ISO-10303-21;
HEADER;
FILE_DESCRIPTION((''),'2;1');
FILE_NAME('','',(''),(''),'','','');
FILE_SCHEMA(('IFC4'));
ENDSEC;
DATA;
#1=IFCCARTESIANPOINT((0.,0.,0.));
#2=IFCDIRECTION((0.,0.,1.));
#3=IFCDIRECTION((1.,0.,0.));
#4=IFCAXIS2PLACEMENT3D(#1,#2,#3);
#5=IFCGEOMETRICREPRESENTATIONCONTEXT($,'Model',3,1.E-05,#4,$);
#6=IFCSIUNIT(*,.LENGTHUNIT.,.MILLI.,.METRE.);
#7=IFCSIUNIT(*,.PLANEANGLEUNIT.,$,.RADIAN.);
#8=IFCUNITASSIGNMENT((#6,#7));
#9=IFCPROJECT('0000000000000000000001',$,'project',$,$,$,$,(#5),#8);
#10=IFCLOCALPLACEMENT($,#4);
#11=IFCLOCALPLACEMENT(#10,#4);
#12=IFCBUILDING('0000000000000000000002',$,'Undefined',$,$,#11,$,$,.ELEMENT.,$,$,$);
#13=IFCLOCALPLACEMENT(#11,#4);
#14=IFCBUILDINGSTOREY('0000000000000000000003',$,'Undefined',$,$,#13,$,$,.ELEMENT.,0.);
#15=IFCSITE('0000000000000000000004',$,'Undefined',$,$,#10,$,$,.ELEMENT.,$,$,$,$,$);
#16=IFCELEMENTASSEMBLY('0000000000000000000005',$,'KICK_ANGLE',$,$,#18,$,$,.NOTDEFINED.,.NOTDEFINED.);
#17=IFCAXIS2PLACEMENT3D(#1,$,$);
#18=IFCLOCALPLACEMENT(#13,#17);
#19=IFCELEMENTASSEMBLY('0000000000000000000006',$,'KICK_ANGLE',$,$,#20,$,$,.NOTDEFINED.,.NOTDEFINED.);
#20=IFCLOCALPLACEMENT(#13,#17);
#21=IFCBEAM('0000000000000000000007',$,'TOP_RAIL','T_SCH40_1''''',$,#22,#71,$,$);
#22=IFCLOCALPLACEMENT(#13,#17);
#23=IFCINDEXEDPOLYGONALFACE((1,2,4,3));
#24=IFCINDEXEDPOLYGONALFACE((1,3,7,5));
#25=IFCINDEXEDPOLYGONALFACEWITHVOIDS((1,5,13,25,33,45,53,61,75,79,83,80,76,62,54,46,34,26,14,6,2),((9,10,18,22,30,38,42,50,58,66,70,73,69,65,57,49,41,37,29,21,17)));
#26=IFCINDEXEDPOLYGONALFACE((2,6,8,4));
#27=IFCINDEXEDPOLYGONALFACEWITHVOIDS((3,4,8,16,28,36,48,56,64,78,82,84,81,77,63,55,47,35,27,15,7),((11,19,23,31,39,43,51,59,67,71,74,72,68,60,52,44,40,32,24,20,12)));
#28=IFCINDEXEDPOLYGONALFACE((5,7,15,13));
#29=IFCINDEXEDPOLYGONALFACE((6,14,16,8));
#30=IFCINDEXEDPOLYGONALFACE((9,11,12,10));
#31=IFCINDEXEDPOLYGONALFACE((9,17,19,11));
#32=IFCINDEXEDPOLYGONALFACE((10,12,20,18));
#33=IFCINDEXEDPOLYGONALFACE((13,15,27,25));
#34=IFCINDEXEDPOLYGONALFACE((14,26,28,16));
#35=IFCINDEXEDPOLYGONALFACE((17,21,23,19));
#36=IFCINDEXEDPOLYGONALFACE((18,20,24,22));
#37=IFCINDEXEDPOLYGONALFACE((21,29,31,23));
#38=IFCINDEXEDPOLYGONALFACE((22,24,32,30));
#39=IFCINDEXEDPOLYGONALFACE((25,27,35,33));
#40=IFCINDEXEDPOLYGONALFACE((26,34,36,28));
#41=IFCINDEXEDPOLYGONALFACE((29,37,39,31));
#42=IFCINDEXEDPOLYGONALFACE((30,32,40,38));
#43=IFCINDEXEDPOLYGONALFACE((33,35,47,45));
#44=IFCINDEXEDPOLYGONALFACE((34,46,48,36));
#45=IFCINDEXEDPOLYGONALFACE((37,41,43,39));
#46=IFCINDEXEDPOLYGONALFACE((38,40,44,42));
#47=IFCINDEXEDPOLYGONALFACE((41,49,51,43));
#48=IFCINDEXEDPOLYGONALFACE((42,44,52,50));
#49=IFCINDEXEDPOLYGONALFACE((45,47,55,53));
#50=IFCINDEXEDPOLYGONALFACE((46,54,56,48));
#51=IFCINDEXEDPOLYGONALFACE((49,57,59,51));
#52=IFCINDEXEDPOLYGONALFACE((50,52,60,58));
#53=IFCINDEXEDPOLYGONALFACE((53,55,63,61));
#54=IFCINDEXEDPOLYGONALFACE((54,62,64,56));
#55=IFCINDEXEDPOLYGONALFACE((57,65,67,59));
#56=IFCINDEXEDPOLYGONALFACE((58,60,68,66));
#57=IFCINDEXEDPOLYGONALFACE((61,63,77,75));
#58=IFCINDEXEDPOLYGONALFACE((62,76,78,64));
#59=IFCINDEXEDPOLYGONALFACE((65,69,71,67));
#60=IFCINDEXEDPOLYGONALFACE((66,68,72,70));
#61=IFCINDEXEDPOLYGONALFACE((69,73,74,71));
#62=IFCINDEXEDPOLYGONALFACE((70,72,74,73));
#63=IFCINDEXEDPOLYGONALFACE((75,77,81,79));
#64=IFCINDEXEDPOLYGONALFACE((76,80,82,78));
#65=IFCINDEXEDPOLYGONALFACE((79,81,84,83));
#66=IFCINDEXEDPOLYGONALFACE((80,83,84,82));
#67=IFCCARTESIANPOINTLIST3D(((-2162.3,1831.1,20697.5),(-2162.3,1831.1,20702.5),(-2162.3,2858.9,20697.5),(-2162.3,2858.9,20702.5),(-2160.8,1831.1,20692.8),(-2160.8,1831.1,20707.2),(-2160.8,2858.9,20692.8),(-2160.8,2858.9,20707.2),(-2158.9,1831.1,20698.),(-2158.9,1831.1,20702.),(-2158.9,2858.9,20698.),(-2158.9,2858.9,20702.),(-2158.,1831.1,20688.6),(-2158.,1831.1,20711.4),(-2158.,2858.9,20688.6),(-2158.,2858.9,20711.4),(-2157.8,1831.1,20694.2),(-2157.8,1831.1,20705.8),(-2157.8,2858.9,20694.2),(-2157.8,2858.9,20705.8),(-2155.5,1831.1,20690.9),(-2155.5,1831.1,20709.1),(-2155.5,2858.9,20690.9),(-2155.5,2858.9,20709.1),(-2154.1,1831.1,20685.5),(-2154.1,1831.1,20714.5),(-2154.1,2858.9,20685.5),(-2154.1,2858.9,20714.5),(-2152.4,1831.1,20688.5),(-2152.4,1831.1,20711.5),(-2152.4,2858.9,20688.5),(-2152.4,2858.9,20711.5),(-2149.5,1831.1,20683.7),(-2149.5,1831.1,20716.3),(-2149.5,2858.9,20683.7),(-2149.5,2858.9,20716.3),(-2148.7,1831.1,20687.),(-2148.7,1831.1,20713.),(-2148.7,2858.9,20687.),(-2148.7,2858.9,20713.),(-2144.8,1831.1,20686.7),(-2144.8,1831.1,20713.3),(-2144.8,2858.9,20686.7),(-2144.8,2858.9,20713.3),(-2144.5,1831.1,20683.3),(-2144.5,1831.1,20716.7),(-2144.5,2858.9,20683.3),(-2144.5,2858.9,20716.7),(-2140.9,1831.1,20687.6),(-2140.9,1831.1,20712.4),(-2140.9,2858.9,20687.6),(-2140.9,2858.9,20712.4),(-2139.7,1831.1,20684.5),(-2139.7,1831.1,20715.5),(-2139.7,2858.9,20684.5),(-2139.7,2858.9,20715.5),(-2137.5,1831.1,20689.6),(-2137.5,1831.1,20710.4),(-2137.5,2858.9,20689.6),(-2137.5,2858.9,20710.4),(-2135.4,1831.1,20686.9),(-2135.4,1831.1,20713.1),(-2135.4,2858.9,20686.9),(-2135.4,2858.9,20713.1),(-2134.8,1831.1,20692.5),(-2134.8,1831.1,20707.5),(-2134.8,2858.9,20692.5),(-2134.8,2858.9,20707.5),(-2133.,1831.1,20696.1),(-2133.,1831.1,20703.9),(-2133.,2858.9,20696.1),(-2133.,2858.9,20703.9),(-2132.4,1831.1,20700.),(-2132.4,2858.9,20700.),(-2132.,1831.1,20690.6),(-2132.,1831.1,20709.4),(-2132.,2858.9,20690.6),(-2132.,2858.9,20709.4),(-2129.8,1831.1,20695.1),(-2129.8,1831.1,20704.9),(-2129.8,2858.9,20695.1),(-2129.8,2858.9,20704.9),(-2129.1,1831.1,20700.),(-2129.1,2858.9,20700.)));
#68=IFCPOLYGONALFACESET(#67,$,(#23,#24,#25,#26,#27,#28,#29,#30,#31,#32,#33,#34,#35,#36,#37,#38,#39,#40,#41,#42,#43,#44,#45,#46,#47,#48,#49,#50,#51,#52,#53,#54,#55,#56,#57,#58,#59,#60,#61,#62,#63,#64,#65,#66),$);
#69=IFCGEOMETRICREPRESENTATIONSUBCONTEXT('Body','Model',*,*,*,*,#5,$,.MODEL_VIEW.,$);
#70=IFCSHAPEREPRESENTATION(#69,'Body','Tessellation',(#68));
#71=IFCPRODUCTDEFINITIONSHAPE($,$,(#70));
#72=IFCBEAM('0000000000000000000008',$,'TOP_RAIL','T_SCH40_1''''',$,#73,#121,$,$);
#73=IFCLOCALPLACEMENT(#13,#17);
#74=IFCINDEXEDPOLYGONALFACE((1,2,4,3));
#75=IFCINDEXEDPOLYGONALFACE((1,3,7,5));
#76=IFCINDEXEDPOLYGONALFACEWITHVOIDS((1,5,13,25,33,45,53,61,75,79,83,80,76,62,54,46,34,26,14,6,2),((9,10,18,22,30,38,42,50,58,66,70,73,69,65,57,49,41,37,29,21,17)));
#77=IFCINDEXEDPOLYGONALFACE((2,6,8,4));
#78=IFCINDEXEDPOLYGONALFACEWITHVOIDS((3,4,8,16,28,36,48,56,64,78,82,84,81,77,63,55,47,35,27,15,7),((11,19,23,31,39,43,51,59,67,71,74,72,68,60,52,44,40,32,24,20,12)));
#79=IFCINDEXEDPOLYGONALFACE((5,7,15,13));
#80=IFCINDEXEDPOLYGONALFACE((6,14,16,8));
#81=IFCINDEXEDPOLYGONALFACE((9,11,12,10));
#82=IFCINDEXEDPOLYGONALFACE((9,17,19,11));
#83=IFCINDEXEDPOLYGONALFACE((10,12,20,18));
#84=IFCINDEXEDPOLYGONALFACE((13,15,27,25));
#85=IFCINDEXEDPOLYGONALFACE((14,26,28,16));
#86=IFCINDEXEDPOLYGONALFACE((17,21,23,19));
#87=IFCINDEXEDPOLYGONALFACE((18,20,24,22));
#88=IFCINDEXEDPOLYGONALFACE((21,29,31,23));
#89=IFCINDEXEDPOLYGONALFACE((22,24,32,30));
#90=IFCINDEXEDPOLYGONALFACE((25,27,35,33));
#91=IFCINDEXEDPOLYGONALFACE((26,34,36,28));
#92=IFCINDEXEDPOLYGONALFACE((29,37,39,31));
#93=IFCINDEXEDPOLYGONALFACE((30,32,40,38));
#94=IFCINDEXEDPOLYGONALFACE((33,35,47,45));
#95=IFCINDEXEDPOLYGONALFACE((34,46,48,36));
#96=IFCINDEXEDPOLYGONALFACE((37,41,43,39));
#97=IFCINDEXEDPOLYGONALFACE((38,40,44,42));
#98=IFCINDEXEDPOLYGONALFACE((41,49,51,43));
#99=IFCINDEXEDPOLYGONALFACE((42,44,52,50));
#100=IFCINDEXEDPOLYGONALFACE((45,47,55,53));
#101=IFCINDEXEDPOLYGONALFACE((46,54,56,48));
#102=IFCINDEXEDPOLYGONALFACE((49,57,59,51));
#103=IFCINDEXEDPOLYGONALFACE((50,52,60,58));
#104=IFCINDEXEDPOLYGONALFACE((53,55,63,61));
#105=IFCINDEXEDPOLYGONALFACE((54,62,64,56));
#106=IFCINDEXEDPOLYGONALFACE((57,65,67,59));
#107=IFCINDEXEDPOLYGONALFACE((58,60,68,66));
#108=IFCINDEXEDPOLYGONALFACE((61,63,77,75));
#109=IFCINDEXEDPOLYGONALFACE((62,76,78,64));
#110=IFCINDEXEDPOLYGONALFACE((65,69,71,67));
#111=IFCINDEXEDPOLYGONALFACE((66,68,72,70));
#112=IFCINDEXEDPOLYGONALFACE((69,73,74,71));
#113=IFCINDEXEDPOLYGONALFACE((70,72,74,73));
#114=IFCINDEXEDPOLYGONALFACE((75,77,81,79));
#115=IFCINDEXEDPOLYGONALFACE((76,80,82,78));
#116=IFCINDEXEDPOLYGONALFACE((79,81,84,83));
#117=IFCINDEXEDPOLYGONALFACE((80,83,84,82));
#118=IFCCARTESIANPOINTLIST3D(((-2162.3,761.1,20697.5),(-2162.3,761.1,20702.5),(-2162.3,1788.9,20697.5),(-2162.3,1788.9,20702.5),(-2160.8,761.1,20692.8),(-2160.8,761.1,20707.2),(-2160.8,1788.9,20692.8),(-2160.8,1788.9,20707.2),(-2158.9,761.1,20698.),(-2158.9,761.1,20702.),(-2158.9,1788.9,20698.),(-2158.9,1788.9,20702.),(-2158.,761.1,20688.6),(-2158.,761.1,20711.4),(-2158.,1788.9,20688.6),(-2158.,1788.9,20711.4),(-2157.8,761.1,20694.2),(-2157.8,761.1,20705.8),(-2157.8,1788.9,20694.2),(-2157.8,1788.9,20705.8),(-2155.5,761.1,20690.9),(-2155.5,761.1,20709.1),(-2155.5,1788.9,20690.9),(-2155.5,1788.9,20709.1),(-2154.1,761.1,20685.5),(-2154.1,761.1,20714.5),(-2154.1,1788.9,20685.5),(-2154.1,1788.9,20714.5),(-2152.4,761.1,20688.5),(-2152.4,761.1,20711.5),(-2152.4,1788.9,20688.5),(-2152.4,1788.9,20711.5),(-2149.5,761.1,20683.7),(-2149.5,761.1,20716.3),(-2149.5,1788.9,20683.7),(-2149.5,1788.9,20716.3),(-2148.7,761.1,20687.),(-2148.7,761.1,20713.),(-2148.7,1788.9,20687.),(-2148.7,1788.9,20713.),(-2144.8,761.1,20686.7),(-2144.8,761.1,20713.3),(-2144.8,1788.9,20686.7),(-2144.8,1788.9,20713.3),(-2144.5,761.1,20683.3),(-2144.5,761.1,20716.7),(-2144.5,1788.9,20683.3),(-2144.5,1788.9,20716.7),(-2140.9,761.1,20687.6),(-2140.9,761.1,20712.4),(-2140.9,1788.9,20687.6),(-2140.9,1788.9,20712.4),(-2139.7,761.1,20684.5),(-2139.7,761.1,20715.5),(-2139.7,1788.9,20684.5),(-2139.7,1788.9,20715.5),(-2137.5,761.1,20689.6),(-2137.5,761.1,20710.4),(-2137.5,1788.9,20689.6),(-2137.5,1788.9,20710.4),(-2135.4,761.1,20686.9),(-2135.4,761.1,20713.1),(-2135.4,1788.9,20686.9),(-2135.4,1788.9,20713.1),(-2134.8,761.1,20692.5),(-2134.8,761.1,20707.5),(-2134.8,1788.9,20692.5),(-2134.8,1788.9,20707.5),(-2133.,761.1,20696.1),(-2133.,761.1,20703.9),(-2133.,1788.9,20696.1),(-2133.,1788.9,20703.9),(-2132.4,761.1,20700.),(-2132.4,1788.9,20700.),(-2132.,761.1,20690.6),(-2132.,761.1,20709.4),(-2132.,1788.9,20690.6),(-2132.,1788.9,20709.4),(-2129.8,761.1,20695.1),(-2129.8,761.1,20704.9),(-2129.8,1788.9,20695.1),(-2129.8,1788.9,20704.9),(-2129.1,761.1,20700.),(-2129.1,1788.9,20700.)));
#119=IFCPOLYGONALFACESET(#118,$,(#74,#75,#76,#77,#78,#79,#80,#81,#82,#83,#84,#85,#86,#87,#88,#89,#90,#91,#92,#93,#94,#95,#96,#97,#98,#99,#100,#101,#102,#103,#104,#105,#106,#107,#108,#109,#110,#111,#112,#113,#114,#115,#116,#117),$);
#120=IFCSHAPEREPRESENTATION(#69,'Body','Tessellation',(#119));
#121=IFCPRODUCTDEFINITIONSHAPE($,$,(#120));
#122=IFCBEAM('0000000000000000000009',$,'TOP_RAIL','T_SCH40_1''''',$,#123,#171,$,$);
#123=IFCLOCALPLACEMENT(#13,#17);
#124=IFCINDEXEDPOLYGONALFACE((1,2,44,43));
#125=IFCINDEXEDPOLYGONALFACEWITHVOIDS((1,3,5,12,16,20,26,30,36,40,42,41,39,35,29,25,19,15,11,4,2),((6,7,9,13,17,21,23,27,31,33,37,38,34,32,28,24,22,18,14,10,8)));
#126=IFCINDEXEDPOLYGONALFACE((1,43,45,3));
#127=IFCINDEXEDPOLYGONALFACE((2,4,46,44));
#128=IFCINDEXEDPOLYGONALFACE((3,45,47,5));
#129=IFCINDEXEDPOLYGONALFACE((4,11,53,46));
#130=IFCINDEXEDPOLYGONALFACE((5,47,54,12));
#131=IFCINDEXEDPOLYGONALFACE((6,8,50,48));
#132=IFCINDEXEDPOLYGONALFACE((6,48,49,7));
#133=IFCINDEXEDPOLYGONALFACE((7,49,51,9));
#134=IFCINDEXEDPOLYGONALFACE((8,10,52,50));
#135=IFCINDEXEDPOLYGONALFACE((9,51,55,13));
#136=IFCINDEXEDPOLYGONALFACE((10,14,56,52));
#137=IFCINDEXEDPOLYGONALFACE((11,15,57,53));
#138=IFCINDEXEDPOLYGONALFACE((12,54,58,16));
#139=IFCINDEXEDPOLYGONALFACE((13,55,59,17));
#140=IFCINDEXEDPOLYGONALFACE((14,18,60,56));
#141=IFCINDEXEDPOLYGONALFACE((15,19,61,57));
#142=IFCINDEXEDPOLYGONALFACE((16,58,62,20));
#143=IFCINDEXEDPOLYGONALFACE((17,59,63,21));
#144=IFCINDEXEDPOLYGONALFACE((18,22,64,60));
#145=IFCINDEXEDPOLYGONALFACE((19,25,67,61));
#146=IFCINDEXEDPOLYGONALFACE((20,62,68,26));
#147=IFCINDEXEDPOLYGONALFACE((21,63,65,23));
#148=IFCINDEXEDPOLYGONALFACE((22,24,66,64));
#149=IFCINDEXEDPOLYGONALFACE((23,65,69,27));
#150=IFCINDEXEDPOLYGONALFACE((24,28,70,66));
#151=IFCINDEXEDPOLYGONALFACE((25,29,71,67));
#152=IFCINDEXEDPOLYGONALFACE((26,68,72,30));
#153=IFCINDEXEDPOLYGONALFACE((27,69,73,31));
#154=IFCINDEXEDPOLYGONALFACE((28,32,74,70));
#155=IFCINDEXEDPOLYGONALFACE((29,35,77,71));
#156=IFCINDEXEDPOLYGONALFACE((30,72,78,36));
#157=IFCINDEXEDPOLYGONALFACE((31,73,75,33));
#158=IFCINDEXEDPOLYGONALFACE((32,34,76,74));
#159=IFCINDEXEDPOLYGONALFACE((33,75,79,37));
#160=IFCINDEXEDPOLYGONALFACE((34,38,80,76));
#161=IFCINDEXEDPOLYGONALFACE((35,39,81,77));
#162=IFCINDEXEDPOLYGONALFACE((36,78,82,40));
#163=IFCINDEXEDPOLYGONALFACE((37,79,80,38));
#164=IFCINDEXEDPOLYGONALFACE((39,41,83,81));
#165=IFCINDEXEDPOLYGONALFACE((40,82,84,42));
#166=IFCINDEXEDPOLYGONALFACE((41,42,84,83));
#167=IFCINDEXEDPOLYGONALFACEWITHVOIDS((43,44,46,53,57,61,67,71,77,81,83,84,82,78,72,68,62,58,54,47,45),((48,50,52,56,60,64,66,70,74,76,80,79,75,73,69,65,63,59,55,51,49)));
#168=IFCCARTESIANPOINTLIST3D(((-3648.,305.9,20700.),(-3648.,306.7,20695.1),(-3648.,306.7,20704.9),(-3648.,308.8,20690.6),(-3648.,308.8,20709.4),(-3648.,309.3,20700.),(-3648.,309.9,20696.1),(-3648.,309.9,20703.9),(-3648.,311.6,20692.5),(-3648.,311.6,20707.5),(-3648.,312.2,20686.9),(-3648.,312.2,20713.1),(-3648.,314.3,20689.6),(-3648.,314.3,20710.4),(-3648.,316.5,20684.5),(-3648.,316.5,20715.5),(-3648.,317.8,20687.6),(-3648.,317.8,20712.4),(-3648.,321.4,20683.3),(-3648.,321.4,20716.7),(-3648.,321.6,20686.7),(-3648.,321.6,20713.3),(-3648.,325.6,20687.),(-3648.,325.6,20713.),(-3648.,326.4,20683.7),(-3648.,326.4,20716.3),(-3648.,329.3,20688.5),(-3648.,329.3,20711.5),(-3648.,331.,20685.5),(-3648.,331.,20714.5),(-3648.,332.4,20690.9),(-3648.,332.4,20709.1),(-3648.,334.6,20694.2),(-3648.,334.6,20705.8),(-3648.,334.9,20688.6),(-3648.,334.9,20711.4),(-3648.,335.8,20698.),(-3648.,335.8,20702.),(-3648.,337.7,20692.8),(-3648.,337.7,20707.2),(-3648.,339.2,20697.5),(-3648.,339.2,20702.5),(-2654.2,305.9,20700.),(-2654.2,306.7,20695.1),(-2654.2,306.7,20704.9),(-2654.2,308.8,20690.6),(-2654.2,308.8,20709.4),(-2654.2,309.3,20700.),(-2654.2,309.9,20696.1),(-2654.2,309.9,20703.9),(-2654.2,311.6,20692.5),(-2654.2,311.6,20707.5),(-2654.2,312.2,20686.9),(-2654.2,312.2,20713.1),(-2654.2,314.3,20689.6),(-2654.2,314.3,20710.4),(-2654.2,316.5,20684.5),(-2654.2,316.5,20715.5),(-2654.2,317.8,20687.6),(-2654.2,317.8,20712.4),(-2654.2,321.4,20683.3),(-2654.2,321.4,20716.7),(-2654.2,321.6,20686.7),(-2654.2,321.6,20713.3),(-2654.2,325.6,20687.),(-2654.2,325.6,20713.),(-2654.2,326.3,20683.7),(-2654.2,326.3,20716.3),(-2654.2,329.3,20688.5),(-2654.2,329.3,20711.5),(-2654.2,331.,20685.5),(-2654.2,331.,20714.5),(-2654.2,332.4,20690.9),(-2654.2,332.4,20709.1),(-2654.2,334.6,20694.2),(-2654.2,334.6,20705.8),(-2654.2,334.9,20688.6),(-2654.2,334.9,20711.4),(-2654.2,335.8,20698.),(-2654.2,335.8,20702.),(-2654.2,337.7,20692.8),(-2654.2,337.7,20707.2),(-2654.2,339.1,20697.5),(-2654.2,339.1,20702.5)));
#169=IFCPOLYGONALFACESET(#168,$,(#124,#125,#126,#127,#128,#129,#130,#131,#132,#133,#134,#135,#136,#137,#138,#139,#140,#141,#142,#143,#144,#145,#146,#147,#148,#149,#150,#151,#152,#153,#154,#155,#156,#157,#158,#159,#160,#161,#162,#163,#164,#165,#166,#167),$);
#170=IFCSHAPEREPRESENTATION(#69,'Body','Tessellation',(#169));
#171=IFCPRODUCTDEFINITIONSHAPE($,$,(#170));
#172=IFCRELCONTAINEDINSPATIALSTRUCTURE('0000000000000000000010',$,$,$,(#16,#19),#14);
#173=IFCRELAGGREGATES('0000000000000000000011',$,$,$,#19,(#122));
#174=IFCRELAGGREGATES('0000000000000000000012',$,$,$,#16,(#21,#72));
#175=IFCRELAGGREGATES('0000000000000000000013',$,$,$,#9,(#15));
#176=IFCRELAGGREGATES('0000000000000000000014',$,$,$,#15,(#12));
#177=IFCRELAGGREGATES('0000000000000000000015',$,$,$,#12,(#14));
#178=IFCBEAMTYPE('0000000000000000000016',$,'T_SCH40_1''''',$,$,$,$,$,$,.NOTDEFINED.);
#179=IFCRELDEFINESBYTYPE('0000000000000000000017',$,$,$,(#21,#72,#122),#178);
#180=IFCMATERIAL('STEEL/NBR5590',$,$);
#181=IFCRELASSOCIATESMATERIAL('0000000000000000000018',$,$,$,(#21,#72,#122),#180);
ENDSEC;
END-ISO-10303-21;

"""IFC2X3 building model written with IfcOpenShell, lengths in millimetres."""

from ifc_helpers import new_model, si_unit, frame, origin_with_axes, origin_2d_with_axis, place, context, subcontext, project, spatial, hollow_circle, extrude, material, type_object, element, aggregate, save


model = new_model("IFC2X3")

# Units and contexts
model_context = context("Model", 3, precision=1e-05, world=origin_with_axes())
body_context = subcontext(model_context, "Body", "Model", "MODEL_VIEW")
ifc_project = project(units=[si_unit("LENGTHUNIT", "METRE", prefix="MILLI"), si_unit("PLANEANGLEUNIT", "RADIAN")], contexts=[model_context])

# Site, building, storey
site_placement = place(None, origin_with_axes())
site = spatial("IfcSite", under=ifc_project, at=site_placement, Name="Undefined", CompositionType="ELEMENT")
building_placement = place(site_placement, origin_with_axes())
building = spatial("IfcBuilding", under=site, at=building_placement, Name="Undefined", CompositionType="ELEMENT")
storey_placement = place(building_placement, origin_with_axes())
storey = spatial("IfcBuildingStorey", under=building, at=storey_placement, Name="Undefined", CompositionType="ELEMENT", Elevation=0.0)

# Element assemblies
assembly_1_placement = place(storey_placement, origin_with_axes())
assembly_1 = element("IfcElementAssembly", 1, at=assembly_1_placement, inside=storey, Name="KICK_ANGLE", AssemblyPlace="NOTDEFINED", PredefinedType="NOTDEFINED")
ifc_material_1 = material(Name="STEEL/NBR5590")
assembly_2_placement = place(storey_placement, origin_with_axes())
assembly_2 = element("IfcElementAssembly", 2, at=assembly_2_placement, inside=storey, Name="KICK_ANGLE", AssemblyPlace="NOTDEFINED", PredefinedType="NOTDEFINED")

# Beams
beam_type_1 = type_object("IfcBeamType", Name="T_SCH40_1''", PredefinedType="NOTDEFINED")
beam_1_placement = place(assembly_1_placement, frame((-2145.8, 1831.1, 20700.0), z_axis=(0.0, 0.0, 1.0), x_axis=(0.0, 1.0, 0.0)))
beam_1 = element("IfcBeam", 3, at=beam_1_placement, type_object=beam_type_1, material=ifc_material_1, Name="TOP_RAIL", Description="T_SCH40_1''", context=body_context, shape_type="SweptSolid", body=[
    extrude(hollow_circle(Radius=16.7, WallThickness=3.4, at=origin_2d_with_axis()), frame((1027.8, 0.0, 0.0), z_axis=(-1.0, 0.0, 0.0), x_axis=(0.0, -1.0, 0.0)), (0.0, 0.0, 1.0), 1027.8),
])
beam_2_placement = place(assembly_1_placement, frame((-2145.8, 761.1, 20700.0), z_axis=(0.0, 0.0, 1.0), x_axis=(0.0, 1.0, 0.0)))
beam_2 = element("IfcBeam", 4, at=beam_2_placement, type_object=beam_type_1, material=ifc_material_1, Name="TOP_RAIL", Description="T_SCH40_1''", context=body_context, shape_type="SweptSolid", body=[
    extrude(hollow_circle(Radius=16.7, WallThickness=3.4, at=origin_2d_with_axis()), frame((1027.8, 0.0, 0.0), z_axis=(-1.0, 0.0, 0.0), x_axis=(0.0, -1.0, 0.0)), (0.0, 0.0, 1.0), 1027.8),
])
beam_3_placement = place(assembly_2_placement, frame((-3648.0, 322.6, 20700.0), z_axis=(0.0, 0.0, 1.0), x_axis=(1.0, -0.000013, 0.0)))
beam_3 = element("IfcBeam", 5, at=beam_3_placement, type_object=beam_type_1, material=ifc_material_1, Name="TOP_RAIL", Description="T_SCH40_1''", context=body_context, shape_type="SweptSolid", body=[
    extrude(hollow_circle(Radius=16.7, WallThickness=3.4, at=origin_2d_with_axis()), frame((993.7, 0.0, 0.0), z_axis=(-1.0, 0.0, 0.0), x_axis=(0.0, -1.0, 0.0)), (0.0, 0.0, 1.0), 993.7),
])

aggregate(assembly_2, [beam_3])
aggregate(assembly_1, [beam_1, beam_2])

save(model, "model.ifc")
